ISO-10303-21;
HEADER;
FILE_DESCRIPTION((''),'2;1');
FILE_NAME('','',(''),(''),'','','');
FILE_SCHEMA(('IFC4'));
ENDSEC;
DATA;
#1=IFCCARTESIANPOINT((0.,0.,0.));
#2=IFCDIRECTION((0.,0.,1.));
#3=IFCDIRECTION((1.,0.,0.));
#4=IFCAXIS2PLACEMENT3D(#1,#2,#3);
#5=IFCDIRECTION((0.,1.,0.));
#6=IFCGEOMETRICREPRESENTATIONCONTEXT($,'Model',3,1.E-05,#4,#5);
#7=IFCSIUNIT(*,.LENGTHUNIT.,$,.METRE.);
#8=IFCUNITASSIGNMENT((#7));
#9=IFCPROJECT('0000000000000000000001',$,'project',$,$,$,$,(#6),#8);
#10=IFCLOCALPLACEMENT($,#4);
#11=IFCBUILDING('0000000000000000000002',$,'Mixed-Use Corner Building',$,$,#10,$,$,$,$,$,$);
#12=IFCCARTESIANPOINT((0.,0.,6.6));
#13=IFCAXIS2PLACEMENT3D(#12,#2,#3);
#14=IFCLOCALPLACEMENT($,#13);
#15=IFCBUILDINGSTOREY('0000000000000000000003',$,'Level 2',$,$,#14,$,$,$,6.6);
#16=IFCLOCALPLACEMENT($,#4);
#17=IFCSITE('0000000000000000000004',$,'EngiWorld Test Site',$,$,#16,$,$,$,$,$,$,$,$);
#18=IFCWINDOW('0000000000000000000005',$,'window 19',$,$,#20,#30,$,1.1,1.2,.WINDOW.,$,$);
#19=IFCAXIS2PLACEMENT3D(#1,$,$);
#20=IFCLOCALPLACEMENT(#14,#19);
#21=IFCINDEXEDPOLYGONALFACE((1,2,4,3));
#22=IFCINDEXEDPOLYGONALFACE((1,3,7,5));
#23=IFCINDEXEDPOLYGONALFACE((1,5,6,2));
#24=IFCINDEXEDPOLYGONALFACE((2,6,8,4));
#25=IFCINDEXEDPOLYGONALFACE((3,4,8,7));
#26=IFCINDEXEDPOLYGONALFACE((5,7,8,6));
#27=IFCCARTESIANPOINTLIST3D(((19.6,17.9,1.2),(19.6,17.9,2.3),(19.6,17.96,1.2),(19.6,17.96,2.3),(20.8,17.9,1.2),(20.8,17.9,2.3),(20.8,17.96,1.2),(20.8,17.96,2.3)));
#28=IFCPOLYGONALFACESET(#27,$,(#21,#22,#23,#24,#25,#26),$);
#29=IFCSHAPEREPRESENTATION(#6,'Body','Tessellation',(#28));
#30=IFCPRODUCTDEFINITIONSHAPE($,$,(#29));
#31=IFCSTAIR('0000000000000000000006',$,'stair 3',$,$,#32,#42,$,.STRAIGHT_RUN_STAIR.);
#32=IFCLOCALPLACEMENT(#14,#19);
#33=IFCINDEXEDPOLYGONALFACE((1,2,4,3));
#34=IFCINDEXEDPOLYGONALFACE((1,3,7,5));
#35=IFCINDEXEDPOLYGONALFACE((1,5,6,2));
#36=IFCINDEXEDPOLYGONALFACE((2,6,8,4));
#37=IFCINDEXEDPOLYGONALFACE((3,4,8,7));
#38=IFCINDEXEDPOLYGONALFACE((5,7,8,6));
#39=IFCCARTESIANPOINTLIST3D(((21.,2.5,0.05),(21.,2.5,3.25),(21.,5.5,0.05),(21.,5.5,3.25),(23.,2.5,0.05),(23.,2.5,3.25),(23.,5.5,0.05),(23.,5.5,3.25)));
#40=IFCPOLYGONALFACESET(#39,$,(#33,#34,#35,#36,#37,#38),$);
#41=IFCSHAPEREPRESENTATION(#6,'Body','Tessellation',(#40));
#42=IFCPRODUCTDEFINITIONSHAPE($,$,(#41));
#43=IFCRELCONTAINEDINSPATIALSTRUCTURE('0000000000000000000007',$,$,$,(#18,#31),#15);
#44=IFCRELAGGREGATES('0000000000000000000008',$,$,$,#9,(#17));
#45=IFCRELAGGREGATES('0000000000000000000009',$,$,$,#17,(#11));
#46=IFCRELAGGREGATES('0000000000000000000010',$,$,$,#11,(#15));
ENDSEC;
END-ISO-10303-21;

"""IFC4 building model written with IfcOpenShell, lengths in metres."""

from ifc_helpers import new_model, si_unit, direction, frame, origin_with_axes, origin_2d_with_axis, place, context, project, spatial, rectangle, extrude, element, save


model = new_model("IFC4")

# Units and contexts
model_context = context("Model", 3, precision=1e-05, world=origin_with_axes(), true_north=direction((0.0, 1.0, 0.0)))
ifc_project = project(units=[si_unit("LENGTHUNIT", "METRE")], contexts=[model_context])

# Site, building, storey
site_placement = place(None, origin_with_axes())
site = spatial("IfcSite", under=ifc_project, at=site_placement, Name="EngiWorld Test Site")
building_placement = place(None, origin_with_axes())
building = spatial("IfcBuilding", under=site, at=building_placement, Name="Mixed-Use Corner Building")
storey_placement = place(None, frame((0.0, 0.0, 6.6), z_axis=(0.0, 0.0, 1.0), x_axis=(1.0, 0.0, 0.0)))
storey = spatial("IfcBuildingStorey", under=building, at=storey_placement, Name="Level 2", Elevation=6.6)

# Window
for number, where, z_axis, x_axis, name in (
    (1, (20.2, 17.93, 7.8), (0.0, 0.0, 1.0), (1.0, 0.0, 0.0), "window 19"),
):
    element("IfcWindow", number, at=place(None, frame(where, z_axis=z_axis, x_axis=x_axis)), inside=storey, Name=name, OverallHeight=1.1, OverallWidth=1.2, PredefinedType="WINDOW", context=model_context, shape_type="SweptSolid", body=[
        extrude(rectangle(XDim=1.2, YDim=0.06, at=origin_2d_with_axis()), origin_with_axes(), (0.0, 0.0, 1.0), 1.1),
    ])

# Stair
stair_placement = place(None, frame((22.0, 4.0, 6.65), z_axis=(0.0, 0.0, 1.0), x_axis=(1.0, 0.0, 0.0)))
element("IfcStair", 2, at=stair_placement, inside=storey, Name="stair 3", PredefinedType="STRAIGHT_RUN_STAIR", context=model_context, shape_type="SweptSolid", body=[
    extrude(rectangle(XDim=2.0, YDim=3.0, at=origin_2d_with_axis()), origin_with_axes(), (0.0, 0.0, 1.0), 3.2),
])

save(model, "model.ifc")
